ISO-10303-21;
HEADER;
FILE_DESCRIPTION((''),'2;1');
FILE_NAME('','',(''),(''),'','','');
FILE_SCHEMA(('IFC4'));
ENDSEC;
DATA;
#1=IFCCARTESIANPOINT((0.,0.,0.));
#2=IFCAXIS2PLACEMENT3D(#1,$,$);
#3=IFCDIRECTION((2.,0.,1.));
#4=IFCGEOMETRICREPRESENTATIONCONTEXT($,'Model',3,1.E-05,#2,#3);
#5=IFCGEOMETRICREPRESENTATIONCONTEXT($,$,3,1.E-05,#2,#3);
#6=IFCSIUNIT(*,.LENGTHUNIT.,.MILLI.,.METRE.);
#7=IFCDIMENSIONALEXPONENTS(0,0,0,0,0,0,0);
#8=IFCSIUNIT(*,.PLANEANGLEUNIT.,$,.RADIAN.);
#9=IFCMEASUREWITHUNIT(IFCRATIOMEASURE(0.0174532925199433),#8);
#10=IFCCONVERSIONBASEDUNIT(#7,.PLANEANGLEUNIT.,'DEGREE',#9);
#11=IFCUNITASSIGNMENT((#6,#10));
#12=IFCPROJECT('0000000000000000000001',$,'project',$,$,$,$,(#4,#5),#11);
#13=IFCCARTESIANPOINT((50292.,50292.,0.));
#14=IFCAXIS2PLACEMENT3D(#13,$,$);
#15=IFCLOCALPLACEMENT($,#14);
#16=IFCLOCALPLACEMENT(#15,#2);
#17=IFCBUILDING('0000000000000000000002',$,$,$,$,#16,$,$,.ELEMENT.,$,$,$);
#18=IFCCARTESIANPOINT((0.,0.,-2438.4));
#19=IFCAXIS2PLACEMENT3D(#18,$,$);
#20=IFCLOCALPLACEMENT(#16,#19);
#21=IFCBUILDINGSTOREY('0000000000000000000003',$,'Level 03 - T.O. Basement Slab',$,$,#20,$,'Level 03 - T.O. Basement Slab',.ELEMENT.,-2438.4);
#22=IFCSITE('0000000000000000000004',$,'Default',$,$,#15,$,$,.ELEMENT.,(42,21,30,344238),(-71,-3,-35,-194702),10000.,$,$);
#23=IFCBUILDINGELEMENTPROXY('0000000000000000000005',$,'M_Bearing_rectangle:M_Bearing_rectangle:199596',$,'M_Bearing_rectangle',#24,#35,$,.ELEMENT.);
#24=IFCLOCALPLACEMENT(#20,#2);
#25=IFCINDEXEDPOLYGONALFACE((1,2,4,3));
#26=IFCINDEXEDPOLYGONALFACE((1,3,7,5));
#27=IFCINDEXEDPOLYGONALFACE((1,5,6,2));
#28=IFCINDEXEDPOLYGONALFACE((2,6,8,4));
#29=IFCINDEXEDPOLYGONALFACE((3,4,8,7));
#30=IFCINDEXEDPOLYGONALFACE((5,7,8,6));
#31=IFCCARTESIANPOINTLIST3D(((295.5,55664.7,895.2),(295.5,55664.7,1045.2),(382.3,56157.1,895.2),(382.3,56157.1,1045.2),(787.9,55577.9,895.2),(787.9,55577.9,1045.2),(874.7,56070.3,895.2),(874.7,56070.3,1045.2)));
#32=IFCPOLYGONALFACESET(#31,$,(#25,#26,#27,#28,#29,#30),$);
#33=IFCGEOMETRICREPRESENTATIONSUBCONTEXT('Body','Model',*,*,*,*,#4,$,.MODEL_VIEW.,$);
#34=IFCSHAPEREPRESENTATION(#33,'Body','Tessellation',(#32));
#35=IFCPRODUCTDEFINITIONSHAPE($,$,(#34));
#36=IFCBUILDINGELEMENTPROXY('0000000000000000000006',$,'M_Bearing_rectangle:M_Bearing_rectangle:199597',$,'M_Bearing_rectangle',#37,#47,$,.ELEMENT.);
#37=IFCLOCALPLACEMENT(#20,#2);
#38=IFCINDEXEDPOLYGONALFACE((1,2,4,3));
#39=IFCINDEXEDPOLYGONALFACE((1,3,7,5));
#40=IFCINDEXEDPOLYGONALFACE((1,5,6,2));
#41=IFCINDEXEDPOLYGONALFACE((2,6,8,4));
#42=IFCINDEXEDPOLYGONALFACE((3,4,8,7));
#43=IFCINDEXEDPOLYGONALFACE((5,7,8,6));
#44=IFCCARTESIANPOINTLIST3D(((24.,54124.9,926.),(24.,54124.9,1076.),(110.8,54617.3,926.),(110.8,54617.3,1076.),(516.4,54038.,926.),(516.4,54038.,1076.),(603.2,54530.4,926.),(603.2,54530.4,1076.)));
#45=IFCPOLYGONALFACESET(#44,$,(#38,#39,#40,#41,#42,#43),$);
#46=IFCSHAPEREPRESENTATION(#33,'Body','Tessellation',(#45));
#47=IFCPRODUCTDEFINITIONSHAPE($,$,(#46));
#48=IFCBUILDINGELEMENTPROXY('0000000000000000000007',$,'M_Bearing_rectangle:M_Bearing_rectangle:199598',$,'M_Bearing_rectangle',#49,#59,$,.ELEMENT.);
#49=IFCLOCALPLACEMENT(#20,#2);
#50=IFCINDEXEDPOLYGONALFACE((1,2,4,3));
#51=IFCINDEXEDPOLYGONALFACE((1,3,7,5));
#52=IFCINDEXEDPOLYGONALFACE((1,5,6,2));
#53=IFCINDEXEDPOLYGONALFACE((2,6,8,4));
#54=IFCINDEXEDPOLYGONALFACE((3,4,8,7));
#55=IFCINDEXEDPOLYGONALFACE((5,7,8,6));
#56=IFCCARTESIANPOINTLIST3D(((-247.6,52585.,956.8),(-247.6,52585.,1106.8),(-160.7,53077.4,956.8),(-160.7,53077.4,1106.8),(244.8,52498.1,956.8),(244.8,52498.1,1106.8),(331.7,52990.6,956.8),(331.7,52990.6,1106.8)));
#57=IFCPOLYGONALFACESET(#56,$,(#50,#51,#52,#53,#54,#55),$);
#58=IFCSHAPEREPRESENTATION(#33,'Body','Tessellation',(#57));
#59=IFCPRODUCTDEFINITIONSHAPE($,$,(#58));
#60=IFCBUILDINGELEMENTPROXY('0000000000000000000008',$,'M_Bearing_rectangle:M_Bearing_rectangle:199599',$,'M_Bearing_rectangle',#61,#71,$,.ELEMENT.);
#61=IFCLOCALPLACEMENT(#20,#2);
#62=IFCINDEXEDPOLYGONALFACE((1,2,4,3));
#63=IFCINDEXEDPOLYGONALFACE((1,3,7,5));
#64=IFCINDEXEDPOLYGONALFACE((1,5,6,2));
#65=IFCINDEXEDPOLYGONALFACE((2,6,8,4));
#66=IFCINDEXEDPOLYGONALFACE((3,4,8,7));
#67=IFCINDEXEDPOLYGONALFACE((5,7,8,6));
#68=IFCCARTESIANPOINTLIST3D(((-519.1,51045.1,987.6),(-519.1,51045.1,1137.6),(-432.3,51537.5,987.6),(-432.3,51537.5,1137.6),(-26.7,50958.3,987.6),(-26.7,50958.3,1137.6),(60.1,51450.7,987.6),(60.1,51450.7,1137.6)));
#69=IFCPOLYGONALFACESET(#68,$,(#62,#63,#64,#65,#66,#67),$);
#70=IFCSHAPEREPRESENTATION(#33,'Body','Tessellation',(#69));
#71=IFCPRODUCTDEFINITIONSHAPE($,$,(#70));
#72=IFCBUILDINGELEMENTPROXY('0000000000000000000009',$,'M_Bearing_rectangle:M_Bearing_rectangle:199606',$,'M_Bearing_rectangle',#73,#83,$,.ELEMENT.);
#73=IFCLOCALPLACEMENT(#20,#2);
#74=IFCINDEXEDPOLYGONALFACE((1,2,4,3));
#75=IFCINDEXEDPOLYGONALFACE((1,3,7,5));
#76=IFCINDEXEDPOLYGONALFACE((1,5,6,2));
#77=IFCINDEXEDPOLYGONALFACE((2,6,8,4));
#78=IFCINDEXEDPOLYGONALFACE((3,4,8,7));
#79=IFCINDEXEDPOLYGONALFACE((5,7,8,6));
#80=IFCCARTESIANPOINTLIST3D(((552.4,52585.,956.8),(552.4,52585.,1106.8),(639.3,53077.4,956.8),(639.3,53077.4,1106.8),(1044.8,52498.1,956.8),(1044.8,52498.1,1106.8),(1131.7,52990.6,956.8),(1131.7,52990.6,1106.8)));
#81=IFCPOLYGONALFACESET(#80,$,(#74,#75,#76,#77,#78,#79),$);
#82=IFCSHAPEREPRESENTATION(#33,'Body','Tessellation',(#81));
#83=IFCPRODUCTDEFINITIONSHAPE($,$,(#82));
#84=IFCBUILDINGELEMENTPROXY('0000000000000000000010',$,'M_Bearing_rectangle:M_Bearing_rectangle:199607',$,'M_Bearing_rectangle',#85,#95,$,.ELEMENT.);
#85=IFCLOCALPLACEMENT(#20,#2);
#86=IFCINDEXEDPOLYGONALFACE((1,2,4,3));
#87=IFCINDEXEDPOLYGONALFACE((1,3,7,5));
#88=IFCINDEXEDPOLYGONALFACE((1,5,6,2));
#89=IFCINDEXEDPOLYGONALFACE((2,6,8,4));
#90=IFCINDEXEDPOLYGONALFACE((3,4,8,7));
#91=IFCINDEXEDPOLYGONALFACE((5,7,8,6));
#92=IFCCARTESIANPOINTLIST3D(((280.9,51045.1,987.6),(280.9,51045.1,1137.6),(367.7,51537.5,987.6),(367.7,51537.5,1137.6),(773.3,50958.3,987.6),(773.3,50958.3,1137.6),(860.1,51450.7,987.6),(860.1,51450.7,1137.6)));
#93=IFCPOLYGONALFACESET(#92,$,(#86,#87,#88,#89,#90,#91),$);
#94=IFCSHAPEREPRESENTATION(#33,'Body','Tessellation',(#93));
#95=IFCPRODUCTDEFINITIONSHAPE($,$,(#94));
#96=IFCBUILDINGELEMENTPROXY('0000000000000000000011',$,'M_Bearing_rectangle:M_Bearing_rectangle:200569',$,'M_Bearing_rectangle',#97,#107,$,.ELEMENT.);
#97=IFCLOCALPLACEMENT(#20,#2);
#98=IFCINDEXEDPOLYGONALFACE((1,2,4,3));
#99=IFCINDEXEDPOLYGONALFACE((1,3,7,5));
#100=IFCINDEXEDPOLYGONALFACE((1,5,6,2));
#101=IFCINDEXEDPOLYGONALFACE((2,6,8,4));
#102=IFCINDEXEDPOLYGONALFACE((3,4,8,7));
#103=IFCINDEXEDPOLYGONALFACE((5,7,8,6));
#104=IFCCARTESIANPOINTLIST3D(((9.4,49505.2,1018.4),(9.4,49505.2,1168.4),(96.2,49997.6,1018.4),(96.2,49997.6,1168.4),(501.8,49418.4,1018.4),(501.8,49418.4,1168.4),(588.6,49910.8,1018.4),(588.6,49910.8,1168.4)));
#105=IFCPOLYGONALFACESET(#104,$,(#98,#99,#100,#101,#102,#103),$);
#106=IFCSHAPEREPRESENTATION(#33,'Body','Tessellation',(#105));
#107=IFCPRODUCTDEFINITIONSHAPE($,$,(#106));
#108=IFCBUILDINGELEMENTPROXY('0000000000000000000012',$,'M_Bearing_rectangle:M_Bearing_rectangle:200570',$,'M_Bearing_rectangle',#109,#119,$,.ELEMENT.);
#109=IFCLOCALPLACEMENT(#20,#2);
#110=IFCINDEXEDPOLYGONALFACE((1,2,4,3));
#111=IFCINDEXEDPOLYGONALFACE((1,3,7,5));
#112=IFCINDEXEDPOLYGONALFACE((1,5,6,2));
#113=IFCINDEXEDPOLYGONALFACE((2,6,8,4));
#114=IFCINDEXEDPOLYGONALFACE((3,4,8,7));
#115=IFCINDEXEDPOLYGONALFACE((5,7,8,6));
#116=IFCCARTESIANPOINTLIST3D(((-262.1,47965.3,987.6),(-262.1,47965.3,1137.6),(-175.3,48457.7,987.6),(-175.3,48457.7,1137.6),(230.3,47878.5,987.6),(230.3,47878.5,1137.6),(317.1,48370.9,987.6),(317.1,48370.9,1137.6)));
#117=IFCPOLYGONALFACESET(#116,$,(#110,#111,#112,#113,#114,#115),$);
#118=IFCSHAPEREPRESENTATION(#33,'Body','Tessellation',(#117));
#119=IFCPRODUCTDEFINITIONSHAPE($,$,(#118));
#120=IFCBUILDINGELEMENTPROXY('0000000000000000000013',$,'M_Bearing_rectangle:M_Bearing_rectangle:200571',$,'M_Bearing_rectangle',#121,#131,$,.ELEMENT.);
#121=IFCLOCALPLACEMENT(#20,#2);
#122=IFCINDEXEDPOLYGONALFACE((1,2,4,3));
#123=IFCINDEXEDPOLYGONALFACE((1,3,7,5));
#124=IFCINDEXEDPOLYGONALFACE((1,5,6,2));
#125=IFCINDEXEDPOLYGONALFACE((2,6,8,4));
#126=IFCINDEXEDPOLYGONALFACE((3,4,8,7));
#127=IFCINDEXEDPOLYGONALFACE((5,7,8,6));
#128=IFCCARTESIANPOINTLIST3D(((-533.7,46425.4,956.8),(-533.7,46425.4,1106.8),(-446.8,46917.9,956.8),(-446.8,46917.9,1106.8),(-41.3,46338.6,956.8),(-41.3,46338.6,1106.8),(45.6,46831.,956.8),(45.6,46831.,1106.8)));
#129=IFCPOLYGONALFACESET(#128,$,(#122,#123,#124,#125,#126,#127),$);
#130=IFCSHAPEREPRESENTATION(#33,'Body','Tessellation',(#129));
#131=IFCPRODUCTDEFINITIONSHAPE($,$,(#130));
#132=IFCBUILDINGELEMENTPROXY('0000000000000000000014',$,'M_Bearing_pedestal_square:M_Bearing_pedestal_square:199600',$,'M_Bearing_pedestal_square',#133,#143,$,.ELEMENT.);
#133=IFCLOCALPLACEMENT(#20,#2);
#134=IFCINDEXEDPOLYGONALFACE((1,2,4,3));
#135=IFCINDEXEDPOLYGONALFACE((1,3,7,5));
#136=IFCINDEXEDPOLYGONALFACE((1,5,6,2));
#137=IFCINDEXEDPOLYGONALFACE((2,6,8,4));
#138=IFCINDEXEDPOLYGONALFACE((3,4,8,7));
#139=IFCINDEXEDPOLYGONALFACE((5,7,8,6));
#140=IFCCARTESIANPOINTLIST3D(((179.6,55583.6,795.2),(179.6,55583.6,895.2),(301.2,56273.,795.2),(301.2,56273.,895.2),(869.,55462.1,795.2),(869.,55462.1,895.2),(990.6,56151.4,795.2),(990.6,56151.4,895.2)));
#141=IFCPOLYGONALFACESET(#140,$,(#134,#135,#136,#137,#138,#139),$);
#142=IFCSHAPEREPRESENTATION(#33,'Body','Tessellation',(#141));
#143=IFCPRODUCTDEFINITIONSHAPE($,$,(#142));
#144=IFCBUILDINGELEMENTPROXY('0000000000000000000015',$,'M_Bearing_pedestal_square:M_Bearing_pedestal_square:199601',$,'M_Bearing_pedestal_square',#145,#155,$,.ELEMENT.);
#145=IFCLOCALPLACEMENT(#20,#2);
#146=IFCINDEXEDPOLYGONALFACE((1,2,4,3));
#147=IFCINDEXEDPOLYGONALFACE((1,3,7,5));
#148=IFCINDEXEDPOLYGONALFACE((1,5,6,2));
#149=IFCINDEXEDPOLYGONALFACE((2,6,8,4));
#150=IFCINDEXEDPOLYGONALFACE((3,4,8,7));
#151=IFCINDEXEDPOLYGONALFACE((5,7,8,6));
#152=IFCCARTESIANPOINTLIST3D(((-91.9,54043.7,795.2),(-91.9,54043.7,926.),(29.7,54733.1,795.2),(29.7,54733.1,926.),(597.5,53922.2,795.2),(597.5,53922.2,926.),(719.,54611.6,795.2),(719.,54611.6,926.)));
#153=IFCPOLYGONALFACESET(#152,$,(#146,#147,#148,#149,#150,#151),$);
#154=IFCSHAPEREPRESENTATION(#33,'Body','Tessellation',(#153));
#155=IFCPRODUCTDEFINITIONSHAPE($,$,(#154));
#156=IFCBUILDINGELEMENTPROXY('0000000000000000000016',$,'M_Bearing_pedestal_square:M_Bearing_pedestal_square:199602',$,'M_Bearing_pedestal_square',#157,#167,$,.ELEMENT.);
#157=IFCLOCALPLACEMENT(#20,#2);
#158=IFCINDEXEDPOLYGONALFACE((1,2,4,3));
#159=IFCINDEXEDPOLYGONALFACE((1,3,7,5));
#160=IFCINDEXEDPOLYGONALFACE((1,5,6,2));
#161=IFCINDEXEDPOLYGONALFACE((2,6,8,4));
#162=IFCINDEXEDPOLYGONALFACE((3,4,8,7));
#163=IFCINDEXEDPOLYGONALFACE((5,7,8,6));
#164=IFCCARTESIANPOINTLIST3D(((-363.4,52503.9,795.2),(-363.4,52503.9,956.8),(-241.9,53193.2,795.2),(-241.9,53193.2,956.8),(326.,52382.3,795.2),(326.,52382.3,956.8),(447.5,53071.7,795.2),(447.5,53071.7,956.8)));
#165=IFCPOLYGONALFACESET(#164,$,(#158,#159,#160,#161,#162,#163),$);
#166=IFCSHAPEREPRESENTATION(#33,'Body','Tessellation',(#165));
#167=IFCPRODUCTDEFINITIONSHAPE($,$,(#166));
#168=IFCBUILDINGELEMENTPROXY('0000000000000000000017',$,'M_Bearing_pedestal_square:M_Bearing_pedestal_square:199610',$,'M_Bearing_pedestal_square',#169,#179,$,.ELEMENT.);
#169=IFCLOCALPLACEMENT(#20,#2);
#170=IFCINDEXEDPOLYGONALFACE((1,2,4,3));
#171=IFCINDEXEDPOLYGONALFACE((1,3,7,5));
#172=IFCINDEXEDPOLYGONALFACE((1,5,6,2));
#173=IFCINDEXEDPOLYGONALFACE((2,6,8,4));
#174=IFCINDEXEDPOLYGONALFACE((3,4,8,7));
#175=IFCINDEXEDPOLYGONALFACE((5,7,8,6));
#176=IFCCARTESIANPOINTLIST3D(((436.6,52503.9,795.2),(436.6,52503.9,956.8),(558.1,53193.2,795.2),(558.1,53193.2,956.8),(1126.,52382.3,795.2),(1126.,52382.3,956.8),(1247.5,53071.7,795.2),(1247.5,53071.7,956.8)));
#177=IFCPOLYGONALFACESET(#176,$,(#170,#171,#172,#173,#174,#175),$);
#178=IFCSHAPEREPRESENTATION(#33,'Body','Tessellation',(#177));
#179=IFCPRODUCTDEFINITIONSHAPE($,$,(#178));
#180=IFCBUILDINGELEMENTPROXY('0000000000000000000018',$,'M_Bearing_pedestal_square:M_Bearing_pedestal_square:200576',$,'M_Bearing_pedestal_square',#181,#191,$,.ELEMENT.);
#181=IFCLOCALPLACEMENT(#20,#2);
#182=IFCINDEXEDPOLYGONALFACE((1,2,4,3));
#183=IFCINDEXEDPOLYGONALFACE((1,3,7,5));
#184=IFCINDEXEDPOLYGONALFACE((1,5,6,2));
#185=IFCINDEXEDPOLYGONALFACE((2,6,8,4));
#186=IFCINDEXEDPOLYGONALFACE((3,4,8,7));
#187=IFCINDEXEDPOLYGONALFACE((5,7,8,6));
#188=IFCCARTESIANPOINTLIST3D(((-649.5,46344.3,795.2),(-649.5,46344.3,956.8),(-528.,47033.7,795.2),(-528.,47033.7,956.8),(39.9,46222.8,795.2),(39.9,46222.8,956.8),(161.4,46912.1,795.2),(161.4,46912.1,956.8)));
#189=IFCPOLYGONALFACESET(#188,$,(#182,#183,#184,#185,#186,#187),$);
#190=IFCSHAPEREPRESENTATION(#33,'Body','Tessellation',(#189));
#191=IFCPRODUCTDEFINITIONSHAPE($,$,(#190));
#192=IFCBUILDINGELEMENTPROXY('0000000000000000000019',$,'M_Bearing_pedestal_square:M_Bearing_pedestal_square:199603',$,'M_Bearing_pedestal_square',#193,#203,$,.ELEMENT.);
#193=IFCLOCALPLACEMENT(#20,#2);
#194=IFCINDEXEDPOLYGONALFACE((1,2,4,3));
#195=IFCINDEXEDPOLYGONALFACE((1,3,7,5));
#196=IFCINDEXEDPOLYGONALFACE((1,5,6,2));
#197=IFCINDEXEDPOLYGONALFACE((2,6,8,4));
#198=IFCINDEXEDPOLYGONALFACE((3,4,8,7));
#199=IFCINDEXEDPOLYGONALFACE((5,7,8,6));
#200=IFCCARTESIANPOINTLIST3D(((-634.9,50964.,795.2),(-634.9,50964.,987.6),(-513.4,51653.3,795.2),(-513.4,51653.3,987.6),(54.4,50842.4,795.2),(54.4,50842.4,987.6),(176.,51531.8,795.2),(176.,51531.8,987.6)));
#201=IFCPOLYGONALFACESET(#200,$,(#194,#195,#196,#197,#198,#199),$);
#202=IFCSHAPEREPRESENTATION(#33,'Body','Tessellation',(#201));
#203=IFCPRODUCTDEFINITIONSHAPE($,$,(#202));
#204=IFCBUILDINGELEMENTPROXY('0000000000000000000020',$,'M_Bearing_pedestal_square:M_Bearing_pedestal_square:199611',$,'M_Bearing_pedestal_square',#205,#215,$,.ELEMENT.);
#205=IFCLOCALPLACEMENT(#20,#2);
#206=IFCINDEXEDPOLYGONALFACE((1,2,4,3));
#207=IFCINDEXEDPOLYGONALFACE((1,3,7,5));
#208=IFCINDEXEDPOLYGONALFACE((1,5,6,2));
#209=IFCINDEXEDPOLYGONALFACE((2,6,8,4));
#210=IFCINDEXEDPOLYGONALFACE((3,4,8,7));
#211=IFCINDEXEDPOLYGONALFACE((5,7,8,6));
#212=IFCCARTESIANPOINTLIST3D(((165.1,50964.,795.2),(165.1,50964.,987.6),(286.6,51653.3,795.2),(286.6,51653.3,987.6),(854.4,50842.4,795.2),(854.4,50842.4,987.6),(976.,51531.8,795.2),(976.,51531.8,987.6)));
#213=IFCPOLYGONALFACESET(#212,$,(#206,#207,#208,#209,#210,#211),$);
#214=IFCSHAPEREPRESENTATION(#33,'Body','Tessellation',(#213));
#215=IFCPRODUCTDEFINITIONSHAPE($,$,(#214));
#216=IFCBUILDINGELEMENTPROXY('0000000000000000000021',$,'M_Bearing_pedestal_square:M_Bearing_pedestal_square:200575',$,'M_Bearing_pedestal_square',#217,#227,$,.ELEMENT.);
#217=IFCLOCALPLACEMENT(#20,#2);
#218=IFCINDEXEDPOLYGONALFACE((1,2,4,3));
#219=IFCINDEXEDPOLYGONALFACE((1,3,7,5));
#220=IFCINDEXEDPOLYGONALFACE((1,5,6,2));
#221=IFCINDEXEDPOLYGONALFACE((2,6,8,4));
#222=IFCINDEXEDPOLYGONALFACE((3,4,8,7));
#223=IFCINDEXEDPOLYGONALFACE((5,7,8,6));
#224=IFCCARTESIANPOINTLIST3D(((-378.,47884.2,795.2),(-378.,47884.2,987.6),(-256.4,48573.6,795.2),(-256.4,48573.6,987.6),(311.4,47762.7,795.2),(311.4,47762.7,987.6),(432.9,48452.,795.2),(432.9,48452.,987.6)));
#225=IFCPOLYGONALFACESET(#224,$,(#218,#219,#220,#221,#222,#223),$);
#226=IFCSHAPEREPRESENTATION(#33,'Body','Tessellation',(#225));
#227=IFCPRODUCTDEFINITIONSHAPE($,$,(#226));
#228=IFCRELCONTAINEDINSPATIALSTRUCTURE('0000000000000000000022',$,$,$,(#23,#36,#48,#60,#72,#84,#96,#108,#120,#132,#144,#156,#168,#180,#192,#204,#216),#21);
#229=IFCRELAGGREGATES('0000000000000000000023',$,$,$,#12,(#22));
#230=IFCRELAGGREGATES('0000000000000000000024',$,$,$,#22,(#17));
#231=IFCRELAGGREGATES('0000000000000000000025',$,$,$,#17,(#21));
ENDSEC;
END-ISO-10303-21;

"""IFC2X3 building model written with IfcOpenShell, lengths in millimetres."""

from ifc_helpers import new_model, entity, si_unit, converted_unit, direction, frame, origin, origin_2d_with_axis, place, context, subcontext, project, spatial, rectangle, extrude, source, transform, mapped, element, save


model = new_model("IFC2X3")

# Units and contexts
model_context = context("Model", 3, precision=1e-05, world=origin(), true_north=direction((2.0, 0.0, 1.0)))
context_of_model = context(None, 3, precision=1e-05, world=origin(), true_north=direction((2.0, 0.0, 1.0)))
body_context = subcontext(model_context, "Body", "Model", "MODEL_VIEW")
ifc_project = project(units=[si_unit("LENGTHUNIT", "METRE", prefix="MILLI"), converted_unit("PLANEANGLEUNIT", "DEGREE", entity("IfcRatioMeasure", 0.0174532925199433), si_unit("PLANEANGLEUNIT", "RADIAN"), dimensions=[0, 0, 0, 0, 0, 0, 0])], contexts=[model_context, context_of_model])

# Site, building, storey
site_placement = place(None, frame((50292.0, 50292.0, 0.0)))
site = spatial("IfcSite", under=ifc_project, at=site_placement, Name="Default", CompositionType="ELEMENT", RefLatitude=(42, 21, 30, 344238), RefLongitude=(-71, -3, -35, -194702), RefElevation=10000.0)
building_placement = place(site_placement, origin())
building = spatial("IfcBuilding", under=site, at=building_placement, CompositionType="ELEMENT")
storey_placement = place(building_placement, frame((0.0, 0.0, -2438.4)))
storey = spatial("IfcBuildingStorey", under=building, at=storey_placement, Name="Level 03 - T.O. Basement Slab", LongName="Level 03 - T.O. Basement Slab", CompositionType="ELEMENT", Elevation=-2438.4)

# Building element proxies
shared_shape_1 = source(origin(), body_context, "Body", "SweptSolid", [
    extrude(rectangle(XDim=500.0, YDim=500.0, at=origin_2d_with_axis()), frame((0.0, 0.0, -150.0), z_axis=(0.0, 0.0, 1.0), x_axis=(-1.0, 0.0, 0.0)), (0.0, 0.0, 1.0), 150.0),
])
for number, where, z_axis, x_axis, name in (
    (1, (585.1, 55867.5, 1045.2), (0.0, 0.0, 1.0), (0.173648, 0.984808, 0.0), "M_Bearing_rectangle:M_Bearing_rectangle:199596"),
    (2, (313.6, 54327.6, 1076.0), (0.0, 0.0, 1.0), (0.173648, 0.984808, 0.0), "M_Bearing_rectangle:M_Bearing_rectangle:199597"),
    (3, (42.0, 52787.8, 1106.8), (0.0, 0.0, 1.0), (0.173648, 0.984808, 0.0), "M_Bearing_rectangle:M_Bearing_rectangle:199598"),
    (4, (-229.5, 51247.9, 1137.6), (0.0, 0.0, 1.0), (0.173648, 0.984808, 0.0), "M_Bearing_rectangle:M_Bearing_rectangle:199599"),
    (5, (842.0, 52787.8, 1106.8), (0.0, 0.0, 1.0), (0.173648, 0.984808, 0.0), "M_Bearing_rectangle:M_Bearing_rectangle:199606"),
    (6, (570.5, 51247.9, 1137.6), (0.0, 0.0, 1.0), (0.173648, 0.984808, 0.0), "M_Bearing_rectangle:M_Bearing_rectangle:199607"),
    (7, (299.0, 49708.0, 1168.4), (0.0, 0.0, 1.0), (0.173648, 0.984808, 0.0), "M_Bearing_rectangle:M_Bearing_rectangle:200569"),
    (8, (27.5, 48168.1, 1137.6), (0.0, 0.0, 1.0), (0.173648, 0.984808, 0.0), "M_Bearing_rectangle:M_Bearing_rectangle:200570"),
    (9, (-244.0, 46628.2, 1106.8), (0.0, 0.0, 1.0), (0.173648, 0.984808, 0.0), "M_Bearing_rectangle:M_Bearing_rectangle:200571"),
):
    element("IfcBuildingElementProxy", number, at=place(storey_placement, frame(where, z_axis=z_axis, x_axis=x_axis)), inside=storey, Name=name, ObjectType="M_Bearing_rectangle", CompositionType="ELEMENT", context=body_context, shape_type="MappedRepresentation", body=[
        mapped(shared_shape_1, transform((0.0, 0.0, 0.0), scale=1.0)),
    ])
shared_shape_2 = source(origin(), body_context, "Body", "SweptSolid", [
    extrude(rectangle(XDim=700.0, YDim=700.0, at=origin_2d_with_axis()), frame((0.0, 0.0, -100.0)), (0.0, 0.0, 1.0), 100.0),
])
proxy_1_placement = place(storey_placement, frame((585.1, 55867.5, 895.2), z_axis=(0.0, 0.0, 1.0), x_axis=(0.173648, 0.984808, 0.0)))
element("IfcBuildingElementProxy", 10, at=proxy_1_placement, inside=storey, Name="M_Bearing_pedestal_square:M_Bearing_pedestal_square:199600", ObjectType="M_Bearing_pedestal_square", CompositionType="ELEMENT", context=body_context, shape_type="MappedRepresentation", body=[
    mapped(shared_shape_2, transform((0.0, 0.0, 0.0), scale=1.0)),
])
shared_shape_3 = source(origin(), body_context, "Body", "SweptSolid", [
    extrude(rectangle(XDim=700.0, YDim=700.0, at=origin_2d_with_axis()), frame((0.0, 0.0, -130.8)), (0.0, 0.0, 1.0), 130.8),
])
proxy_2_placement = place(storey_placement, frame((313.6, 54327.6, 926.0), z_axis=(0.0, 0.0, 1.0), x_axis=(0.173648, 0.984808, 0.0)))
element("IfcBuildingElementProxy", 11, at=proxy_2_placement, inside=storey, Name="M_Bearing_pedestal_square:M_Bearing_pedestal_square:199601", ObjectType="M_Bearing_pedestal_square", CompositionType="ELEMENT", context=body_context, shape_type="MappedRepresentation", body=[
    mapped(shared_shape_3, transform((0.0, 0.0, 0.0), scale=1.0)),
])
shared_shape_4 = source(origin(), body_context, "Body", "SweptSolid", [
    extrude(rectangle(XDim=700.0, YDim=700.0, at=origin_2d_with_axis()), frame((0.0, 0.0, -161.6)), (0.0, 0.0, 1.0), 161.6),
])
for number, where, z_axis, x_axis, name in (
    (12, (42.0, 52787.8, 956.8), (0.0, 0.0, 1.0), (0.173648, 0.984808, 0.0), "M_Bearing_pedestal_square:M_Bearing_pedestal_square:199602"),
    (13, (842.0, 52787.8, 956.8), (0.0, 0.0, 1.0), (0.173648, 0.984808, 0.0), "M_Bearing_pedestal_square:M_Bearing_pedestal_square:199610"),
    (14, (-244.0, 46628.2, 956.8), (0.0, 0.0, 1.0), (0.173648, 0.984808, 0.0), "M_Bearing_pedestal_square:M_Bearing_pedestal_square:200576"),
):
    element("IfcBuildingElementProxy", number, at=place(storey_placement, frame(where, z_axis=z_axis, x_axis=x_axis)), inside=storey, Name=name, ObjectType="M_Bearing_pedestal_square", CompositionType="ELEMENT", context=body_context, shape_type="MappedRepresentation", body=[
        mapped(shared_shape_4, transform((0.0, 0.0, 0.0), scale=1.0)),
    ])
shared_shape_5 = source(origin(), body_context, "Body", "SweptSolid", [
    extrude(rectangle(XDim=700.0, YDim=700.0, at=origin_2d_with_axis()), frame((0.0, 0.0, -192.4)), (0.0, 0.0, 1.0), 192.4),
])
for number, where, z_axis, x_axis, name in (
    (15, (-229.5, 51247.9, 987.6), (0.0, 0.0, 1.0), (0.173648, 0.984808, 0.0), "M_Bearing_pedestal_square:M_Bearing_pedestal_square:199603"),
    (16, (570.5, 51247.9, 987.6), (0.0, 0.0, 1.0), (0.173648, 0.984808, 0.0), "M_Bearing_pedestal_square:M_Bearing_pedestal_square:199611"),
    (17, (27.5, 48168.1, 987.6), (0.0, 0.0, 1.0), (0.173648, 0.984808, 0.0), "M_Bearing_pedestal_square:M_Bearing_pedestal_square:200575"),
):
    element("IfcBuildingElementProxy", number, at=place(storey_placement, frame(where, z_axis=z_axis, x_axis=x_axis)), inside=storey, Name=name, ObjectType="M_Bearing_pedestal_square", CompositionType="ELEMENT", context=body_context, shape_type="MappedRepresentation", body=[
        mapped(shared_shape_5, transform((0.0, 0.0, 0.0), scale=1.0)),
    ])

save(model, "model.ifc")
